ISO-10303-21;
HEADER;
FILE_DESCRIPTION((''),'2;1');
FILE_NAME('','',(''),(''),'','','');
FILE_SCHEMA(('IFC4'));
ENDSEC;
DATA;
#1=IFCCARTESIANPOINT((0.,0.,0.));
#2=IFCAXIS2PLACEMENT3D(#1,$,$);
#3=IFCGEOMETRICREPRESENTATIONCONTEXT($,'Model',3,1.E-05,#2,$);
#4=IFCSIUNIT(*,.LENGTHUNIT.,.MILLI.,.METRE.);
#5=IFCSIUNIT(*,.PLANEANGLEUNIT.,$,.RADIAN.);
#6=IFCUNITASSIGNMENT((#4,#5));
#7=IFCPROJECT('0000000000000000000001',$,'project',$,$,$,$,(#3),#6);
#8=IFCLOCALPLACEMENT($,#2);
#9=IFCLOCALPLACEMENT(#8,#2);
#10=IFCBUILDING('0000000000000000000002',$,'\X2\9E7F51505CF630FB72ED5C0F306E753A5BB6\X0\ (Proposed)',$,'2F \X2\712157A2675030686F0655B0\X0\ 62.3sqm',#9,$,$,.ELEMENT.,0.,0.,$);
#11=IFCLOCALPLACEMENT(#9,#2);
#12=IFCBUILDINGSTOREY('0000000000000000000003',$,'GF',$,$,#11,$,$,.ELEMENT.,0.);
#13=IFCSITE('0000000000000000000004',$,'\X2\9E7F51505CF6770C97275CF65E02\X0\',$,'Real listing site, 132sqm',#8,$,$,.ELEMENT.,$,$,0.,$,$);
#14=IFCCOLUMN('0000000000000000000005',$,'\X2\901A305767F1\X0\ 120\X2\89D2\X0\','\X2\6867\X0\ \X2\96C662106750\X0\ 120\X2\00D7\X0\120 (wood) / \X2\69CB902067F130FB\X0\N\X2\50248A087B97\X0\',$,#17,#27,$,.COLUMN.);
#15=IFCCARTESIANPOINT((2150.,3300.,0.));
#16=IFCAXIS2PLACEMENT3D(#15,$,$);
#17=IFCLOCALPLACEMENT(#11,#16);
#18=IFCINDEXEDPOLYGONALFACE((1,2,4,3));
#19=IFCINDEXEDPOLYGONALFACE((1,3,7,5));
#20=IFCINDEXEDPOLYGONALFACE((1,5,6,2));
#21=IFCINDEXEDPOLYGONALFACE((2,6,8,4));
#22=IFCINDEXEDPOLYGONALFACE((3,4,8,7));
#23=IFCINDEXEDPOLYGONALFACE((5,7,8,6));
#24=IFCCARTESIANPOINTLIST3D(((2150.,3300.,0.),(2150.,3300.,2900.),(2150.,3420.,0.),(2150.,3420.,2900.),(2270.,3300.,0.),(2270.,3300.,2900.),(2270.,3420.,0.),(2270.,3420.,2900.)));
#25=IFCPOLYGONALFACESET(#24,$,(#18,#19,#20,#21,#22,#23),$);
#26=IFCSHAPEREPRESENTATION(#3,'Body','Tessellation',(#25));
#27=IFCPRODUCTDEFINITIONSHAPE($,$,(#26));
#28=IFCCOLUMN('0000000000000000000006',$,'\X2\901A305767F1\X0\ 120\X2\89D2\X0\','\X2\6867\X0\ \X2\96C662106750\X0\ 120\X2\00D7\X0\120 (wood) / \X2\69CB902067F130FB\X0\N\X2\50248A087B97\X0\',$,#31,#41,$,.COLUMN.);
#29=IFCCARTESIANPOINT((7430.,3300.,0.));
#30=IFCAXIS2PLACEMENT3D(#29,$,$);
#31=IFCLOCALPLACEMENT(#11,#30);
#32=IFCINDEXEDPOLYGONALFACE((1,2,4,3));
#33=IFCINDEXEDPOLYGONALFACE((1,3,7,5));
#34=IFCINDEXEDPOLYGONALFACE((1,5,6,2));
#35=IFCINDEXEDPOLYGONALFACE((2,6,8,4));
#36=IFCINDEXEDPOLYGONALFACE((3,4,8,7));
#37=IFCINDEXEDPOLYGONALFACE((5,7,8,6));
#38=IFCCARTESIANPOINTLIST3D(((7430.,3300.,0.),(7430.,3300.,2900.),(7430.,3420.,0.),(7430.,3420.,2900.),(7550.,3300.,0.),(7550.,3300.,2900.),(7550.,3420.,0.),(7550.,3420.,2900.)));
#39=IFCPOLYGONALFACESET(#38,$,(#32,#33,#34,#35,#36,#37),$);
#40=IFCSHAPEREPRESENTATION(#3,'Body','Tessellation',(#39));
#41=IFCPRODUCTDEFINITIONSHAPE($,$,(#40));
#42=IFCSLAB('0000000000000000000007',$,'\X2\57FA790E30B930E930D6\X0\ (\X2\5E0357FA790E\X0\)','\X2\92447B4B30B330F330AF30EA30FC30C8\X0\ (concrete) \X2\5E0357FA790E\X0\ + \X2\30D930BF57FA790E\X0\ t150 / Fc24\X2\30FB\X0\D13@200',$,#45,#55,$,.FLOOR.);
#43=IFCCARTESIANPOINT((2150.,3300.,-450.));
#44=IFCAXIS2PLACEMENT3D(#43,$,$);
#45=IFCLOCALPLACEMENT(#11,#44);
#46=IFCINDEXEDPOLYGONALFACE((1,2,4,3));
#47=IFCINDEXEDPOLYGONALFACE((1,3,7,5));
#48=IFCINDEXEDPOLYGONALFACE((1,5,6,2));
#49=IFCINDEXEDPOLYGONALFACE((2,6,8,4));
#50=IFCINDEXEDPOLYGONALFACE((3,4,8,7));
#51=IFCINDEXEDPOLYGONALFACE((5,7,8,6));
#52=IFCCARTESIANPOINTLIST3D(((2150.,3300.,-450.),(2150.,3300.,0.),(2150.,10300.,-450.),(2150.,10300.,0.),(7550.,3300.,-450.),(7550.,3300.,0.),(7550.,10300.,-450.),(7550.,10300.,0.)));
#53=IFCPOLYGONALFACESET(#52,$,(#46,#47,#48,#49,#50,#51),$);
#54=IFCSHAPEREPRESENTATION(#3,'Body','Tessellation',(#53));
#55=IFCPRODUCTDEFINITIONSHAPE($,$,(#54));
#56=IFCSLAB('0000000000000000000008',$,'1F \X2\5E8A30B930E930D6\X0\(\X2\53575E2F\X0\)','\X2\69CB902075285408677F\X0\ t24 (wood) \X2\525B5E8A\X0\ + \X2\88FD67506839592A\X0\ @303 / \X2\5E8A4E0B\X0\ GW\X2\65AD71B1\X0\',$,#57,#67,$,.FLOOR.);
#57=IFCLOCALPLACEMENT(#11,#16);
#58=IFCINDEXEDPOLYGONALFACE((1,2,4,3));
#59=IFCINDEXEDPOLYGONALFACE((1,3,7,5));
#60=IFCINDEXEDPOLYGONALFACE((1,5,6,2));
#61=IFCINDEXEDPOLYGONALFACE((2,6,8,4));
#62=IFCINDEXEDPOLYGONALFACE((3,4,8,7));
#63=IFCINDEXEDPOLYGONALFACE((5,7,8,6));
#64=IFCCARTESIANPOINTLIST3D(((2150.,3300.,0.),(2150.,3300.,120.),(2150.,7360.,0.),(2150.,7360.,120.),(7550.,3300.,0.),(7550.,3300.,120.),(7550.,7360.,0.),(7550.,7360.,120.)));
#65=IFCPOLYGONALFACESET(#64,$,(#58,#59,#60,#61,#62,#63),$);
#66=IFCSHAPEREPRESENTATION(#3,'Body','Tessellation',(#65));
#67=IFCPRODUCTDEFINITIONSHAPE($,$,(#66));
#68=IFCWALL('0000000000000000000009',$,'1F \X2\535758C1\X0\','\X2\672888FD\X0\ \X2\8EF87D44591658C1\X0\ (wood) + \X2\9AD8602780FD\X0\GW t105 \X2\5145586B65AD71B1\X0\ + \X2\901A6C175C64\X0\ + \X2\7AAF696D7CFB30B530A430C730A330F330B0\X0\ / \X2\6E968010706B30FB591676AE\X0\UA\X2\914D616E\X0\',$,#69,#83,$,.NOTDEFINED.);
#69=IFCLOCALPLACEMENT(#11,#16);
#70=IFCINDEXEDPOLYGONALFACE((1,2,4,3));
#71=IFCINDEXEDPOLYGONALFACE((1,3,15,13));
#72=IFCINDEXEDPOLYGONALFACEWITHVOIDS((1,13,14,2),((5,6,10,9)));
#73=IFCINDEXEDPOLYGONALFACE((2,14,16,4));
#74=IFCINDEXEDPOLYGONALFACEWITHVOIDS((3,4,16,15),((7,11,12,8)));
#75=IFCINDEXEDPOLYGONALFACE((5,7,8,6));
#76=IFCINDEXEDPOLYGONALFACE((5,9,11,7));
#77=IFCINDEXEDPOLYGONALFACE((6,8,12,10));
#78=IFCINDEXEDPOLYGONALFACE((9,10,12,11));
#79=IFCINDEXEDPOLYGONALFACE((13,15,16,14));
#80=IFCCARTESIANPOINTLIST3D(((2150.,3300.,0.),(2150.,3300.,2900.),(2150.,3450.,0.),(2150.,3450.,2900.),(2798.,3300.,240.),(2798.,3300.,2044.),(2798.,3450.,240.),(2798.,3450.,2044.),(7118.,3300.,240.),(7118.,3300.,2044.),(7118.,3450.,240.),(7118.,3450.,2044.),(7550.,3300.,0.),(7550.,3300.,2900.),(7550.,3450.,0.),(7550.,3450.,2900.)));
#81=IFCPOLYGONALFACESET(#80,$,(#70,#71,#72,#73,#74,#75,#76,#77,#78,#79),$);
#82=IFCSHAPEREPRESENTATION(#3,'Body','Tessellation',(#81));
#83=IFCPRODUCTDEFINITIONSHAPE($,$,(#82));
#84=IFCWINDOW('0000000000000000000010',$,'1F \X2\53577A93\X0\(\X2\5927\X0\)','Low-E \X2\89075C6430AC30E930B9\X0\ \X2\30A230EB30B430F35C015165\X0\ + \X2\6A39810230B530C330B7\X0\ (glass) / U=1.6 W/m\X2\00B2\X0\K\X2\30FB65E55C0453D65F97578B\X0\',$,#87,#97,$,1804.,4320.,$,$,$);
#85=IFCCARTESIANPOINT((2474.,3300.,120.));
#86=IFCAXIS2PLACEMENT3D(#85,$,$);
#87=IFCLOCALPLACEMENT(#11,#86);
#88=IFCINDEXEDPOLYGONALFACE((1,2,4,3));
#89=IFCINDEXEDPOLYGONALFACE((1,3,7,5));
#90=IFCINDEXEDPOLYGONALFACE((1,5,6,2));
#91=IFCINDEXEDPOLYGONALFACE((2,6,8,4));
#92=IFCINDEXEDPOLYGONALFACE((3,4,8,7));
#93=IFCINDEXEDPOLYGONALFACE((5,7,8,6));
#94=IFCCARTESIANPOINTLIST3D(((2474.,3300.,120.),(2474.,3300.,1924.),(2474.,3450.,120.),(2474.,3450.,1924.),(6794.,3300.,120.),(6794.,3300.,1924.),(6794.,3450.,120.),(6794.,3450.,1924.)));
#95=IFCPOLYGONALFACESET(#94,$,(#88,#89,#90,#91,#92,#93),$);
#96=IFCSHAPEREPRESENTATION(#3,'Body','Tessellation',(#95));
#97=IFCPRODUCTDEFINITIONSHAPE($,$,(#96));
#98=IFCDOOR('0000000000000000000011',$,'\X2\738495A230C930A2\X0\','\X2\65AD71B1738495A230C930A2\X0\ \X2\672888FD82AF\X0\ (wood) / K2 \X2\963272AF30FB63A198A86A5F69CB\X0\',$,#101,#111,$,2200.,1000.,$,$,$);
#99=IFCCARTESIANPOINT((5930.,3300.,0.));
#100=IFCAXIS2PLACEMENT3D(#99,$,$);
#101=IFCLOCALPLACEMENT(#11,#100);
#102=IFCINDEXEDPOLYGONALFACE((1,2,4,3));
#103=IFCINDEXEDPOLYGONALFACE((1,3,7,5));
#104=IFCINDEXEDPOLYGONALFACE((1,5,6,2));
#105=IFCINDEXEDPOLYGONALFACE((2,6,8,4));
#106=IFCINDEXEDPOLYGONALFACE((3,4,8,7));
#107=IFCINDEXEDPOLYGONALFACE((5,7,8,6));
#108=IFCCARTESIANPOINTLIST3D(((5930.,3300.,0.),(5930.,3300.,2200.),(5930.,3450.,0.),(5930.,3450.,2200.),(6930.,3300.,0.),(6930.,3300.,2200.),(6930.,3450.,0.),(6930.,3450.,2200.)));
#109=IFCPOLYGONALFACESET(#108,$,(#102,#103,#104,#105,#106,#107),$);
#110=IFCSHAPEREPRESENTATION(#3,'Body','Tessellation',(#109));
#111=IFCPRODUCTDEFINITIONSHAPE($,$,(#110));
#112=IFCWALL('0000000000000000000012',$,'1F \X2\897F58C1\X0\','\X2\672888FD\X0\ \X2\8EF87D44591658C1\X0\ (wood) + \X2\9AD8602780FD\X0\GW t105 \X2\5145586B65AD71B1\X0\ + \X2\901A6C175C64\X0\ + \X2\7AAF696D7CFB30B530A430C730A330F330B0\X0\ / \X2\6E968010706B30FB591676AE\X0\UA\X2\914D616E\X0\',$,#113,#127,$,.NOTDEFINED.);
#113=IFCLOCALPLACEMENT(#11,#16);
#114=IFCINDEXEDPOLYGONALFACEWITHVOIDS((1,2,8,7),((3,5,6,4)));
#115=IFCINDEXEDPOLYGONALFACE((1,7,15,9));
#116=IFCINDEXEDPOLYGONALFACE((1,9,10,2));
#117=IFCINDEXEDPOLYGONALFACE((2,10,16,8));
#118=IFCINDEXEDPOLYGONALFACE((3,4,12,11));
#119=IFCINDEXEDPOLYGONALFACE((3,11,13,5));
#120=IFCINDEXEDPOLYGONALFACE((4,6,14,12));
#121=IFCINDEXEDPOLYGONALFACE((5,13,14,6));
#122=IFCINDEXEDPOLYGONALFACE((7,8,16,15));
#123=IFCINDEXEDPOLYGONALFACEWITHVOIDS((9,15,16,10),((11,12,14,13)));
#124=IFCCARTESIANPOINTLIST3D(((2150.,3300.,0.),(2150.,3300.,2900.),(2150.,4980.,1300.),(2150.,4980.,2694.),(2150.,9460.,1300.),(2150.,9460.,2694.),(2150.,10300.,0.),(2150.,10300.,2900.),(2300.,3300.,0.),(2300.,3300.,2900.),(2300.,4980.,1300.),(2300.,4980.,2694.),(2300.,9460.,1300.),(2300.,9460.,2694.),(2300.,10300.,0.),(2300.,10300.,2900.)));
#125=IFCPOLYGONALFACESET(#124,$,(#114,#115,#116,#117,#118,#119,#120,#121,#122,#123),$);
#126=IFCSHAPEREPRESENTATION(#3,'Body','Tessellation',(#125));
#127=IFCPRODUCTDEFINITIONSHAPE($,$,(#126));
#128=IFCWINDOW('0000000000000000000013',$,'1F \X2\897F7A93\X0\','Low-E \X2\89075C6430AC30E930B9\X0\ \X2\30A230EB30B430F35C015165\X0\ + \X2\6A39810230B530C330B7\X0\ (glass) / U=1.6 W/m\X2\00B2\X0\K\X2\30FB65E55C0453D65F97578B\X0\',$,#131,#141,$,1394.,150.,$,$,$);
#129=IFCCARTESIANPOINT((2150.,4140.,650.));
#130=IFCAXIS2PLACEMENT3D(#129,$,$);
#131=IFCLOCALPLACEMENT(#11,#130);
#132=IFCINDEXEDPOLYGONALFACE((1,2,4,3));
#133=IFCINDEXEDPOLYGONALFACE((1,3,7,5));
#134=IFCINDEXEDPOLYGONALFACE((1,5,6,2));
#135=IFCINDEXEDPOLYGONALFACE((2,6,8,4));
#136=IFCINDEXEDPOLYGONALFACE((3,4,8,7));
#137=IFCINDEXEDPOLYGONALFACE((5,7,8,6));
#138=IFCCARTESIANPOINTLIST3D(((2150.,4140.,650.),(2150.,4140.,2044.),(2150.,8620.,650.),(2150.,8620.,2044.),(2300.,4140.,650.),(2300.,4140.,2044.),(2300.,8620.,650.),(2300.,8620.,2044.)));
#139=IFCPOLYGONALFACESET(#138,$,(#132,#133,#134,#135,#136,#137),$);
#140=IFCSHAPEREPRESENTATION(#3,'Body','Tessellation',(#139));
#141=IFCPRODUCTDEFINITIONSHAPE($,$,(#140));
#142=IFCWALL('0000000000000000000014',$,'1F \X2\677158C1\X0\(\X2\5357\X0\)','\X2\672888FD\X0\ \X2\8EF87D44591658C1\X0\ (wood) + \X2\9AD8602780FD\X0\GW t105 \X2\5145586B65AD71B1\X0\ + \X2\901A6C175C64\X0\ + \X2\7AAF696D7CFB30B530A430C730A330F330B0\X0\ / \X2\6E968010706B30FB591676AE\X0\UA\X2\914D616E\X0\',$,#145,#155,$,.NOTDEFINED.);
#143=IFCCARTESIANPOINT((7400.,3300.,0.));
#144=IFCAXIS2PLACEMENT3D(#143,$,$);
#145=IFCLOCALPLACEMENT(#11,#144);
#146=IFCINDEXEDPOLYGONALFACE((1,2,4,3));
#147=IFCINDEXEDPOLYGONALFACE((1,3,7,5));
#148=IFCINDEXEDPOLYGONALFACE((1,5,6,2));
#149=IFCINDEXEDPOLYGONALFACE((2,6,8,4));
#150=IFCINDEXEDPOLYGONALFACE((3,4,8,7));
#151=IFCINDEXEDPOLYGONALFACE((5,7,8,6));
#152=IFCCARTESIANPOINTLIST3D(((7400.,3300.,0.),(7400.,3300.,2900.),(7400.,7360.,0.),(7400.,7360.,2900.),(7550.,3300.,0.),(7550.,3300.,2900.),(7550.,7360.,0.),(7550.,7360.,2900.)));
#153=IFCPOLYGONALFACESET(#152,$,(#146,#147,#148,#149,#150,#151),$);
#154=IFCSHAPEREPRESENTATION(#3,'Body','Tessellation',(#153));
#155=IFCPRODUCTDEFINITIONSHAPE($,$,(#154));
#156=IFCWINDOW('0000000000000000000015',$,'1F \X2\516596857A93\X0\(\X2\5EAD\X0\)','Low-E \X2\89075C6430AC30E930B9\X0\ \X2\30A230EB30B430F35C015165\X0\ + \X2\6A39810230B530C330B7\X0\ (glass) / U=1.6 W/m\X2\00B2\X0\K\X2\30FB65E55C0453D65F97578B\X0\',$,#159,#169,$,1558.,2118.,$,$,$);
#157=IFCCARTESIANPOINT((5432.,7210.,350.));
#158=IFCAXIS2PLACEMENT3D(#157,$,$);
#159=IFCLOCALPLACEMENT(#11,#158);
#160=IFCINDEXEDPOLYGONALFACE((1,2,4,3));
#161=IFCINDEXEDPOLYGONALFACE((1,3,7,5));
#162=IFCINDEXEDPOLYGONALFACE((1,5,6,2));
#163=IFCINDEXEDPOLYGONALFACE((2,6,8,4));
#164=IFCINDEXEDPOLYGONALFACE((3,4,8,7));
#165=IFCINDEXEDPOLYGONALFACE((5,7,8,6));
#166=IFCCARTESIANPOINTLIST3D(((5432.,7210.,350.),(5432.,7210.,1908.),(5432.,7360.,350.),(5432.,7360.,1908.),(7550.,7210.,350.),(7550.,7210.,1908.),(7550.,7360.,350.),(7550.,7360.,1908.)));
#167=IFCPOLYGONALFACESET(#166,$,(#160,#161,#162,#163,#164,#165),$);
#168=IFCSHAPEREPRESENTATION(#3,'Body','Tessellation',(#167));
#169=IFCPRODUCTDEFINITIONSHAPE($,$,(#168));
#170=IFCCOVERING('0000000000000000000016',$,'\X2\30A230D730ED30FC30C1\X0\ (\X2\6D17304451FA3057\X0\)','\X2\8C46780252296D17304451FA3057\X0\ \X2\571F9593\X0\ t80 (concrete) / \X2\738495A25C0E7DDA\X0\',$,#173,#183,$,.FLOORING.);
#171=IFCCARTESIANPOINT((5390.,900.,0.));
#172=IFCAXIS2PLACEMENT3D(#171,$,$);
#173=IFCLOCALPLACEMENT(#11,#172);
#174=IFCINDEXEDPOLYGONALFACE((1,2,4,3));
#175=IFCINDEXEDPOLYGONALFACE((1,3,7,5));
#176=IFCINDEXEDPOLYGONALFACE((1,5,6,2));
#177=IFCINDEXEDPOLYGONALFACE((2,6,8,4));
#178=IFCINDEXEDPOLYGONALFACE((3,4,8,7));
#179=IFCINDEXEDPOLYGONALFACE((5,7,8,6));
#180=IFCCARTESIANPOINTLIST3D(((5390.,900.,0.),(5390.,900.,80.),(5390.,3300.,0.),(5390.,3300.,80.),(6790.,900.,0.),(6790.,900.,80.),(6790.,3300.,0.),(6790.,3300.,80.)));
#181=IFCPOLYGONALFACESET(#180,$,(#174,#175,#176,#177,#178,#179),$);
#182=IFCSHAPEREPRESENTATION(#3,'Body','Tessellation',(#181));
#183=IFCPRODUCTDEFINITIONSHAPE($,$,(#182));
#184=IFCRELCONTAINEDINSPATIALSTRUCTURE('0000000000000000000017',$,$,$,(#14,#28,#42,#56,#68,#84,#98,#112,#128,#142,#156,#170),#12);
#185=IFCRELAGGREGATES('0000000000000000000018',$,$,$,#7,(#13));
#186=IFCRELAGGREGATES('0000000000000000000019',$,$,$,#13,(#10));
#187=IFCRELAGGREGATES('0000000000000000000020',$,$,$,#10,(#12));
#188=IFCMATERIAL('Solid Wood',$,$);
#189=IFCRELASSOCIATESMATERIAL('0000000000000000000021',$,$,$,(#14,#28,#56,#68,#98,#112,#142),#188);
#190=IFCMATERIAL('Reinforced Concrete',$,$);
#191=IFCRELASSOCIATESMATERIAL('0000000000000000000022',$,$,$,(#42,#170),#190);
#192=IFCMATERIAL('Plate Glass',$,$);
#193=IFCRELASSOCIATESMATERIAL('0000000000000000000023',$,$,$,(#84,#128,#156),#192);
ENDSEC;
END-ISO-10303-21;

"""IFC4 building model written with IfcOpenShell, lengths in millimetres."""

from ifc_helpers import new_model, si_unit, frame, frame_2d, origin, place, context, project, spatial, rectangle, extrude, material, element, fill, save


model = new_model("IFC4")

# Units and contexts
model_context = context("Model", 3, precision=1e-05, world=origin())
ifc_project = project(units=[si_unit("LENGTHUNIT", "METRE", prefix="MILLI"), si_unit("PLANEANGLEUNIT", "RADIAN")], contexts=[model_context])

# Site, building, storey
site_placement = place(None, origin())
site = spatial("IfcSite", under=ifc_project, at=site_placement, Name="鹿児島県霧島市", ObjectType="Real listing site, 132sqm", CompositionType="ELEMENT", RefElevation=0.0)
building_placement = place(site_placement, origin())
building = spatial("IfcBuilding", under=site, at=building_placement, Name="鹿児島・狭小の町家 (Proposed)", ObjectType="2F 無垢材と漆喰 62.3sqm", CompositionType="ELEMENT", ElevationOfRefHeight=0.0, ElevationOfTerrain=0.0)
storey_placement = place(building_placement, origin())
storey = spatial("IfcBuildingStorey", under=building, at=storey_placement, Name="GF", CompositionType="ELEMENT", Elevation=0.0)

# Columns
ifc_material_1 = material(Name="Solid Wood")
column_1_placement = place(storey_placement, frame((2150.0, 3300.0, 0.0)))
element("IfcColumn", 1, at=column_1_placement, inside=storey, material=ifc_material_1, Name="通し柱 120角", Description="桧 集成材 120×120 (wood) / 構造柱・N値計算", PredefinedType="COLUMN", context=model_context, shape_type="SweptSolid", body=[
    extrude(rectangle(XDim=120.0, YDim=120.0, at=frame_2d((60.0, 60.0))), frame((2150.0, 3300.0, 0.0)), (0.0, 0.0, 1.0), 2900.0),
])
column_2_placement = place(storey_placement, frame((7430.0, 3300.0, 0.0)))
element("IfcColumn", 2, at=column_2_placement, inside=storey, material=ifc_material_1, Name="通し柱 120角", Description="桧 集成材 120×120 (wood) / 構造柱・N値計算", PredefinedType="COLUMN", context=model_context, shape_type="SweptSolid", body=[
    extrude(rectangle(XDim=120.0, YDim=120.0, at=frame_2d((60.0, 60.0))), frame((7430.0, 3300.0, 0.0)), (0.0, 0.0, 1.0), 2900.0),
])

# Slabs
ifc_material_2 = material(Name="Reinforced Concrete")
slab_1_placement = place(storey_placement, frame((2150.0, 3300.0, -450.0)))
element("IfcSlab", 3, at=slab_1_placement, inside=storey, material=ifc_material_2, Name="基礎スラブ (布基礎)", Description="鉄筋コンクリート (concrete) 布基礎 + ベタ基礎 t150 / Fc24・D13@200", PredefinedType="FLOOR", context=model_context, shape_type="SweptSolid", body=[
    extrude(rectangle(XDim=5400.0, YDim=7000.0, at=frame_2d((2700.0, 3500.0))), frame((2150.0, 3300.0, -450.0)), (0.0, 0.0, 1.0), 450.0),
])
slab_2_placement = place(storey_placement, frame((2150.0, 3300.0, 0.0)))
element("IfcSlab", 4, at=slab_2_placement, inside=storey, material=ifc_material_1, Name="1F 床スラブ(南帯)", Description="構造用合板 t24 (wood) 剛床 + 製材根太 @303 / 床下 GW断熱", PredefinedType="FLOOR", context=model_context, shape_type="SweptSolid", body=[
    extrude(rectangle(XDim=5400.0, YDim=4060.0, at=frame_2d((2700.0, 2030.0))), frame((2150.0, 3300.0, 0.0)), (0.0, 0.0, 1.0), 120.0),
])

# Wall, openings, window, door
wall_1_placement = place(storey_placement, frame((2150.0, 3300.0, 0.0)))
wall_1 = element("IfcWall", 5, at=wall_1_placement, inside=storey, material=ifc_material_1, Name="1F 南壁", Description="木製 軸組外壁 (wood) + 高性能GW t105 充填断熱 + 通気層 + 窯業系サイディング / 準耐火・外皮UA配慮", PredefinedType="NOTDEFINED", context=model_context, shape_type="SweptSolid", body=[
    extrude(rectangle(XDim=5400.0, YDim=150.0, at=frame_2d((2700.0, 75.0))), frame((2150.0, 3300.0, 0.0)), (0.0, 0.0, 1.0), 2900.0),
])
opening_1_placement = place(storey_placement, frame((2474.0, 3300.0, 120.0)))
opening_1 = element("IfcOpeningElement", 6, at=opening_1_placement, cuts=wall_1, PredefinedType="NOTDEFINED", context=model_context, shape_type="SweptSolid", body=[
    extrude(rectangle(XDim=4320.0, YDim=150.0, at=frame_2d((2160.0, 75.0))), frame((2474.0, 3300.0, 120.0)), (0.0, 0.0, 1.0), 1804.0),
])
opening_2_placement = place(storey_placement, frame((5930.0, 3300.0, 0.0)))
opening_2 = element("IfcOpeningElement", 7, at=opening_2_placement, cuts=wall_1, PredefinedType="NOTDEFINED", context=model_context, shape_type="SweptSolid", body=[
    extrude(rectangle(XDim=1000.0, YDim=150.0, at=frame_2d((500.0, 75.0))), frame((5930.0, 3300.0, 0.0)), (0.0, 0.0, 1.0), 2200.0),
])
ifc_material_3 = material(Name="Plate Glass")
window_1_placement = place(storey_placement, frame((2474.0, 3300.0, 120.0)))
window_1 = element("IfcWindow", 8, at=window_1_placement, inside=storey, material=ifc_material_3, Name="1F 南窓(大)", Description="Low-E 複層ガラス アルゴン封入 + 樹脂サッシ (glass) / U=1.6 W/m²K・日射取得型", OverallHeight=1804.0, OverallWidth=4320.0, context=model_context, shape_type="SweptSolid", body=[
    extrude(rectangle(XDim=4320.0, YDim=150.0, at=frame_2d((2160.0, 75.0))), frame((2474.0, 3300.0, 120.0)), (0.0, 0.0, 1.0), 1804.0),
])
fill(opening_1, window_1)
door_1_placement = place(storey_placement, frame((5930.0, 3300.0, 0.0)))
door_1 = element("IfcDoor", 9, at=door_1_placement, inside=storey, material=ifc_material_1, Name="玄関ドア", Description="断熱玄関ドア 木製芯 (wood) / K2 防犯・採風機構", OverallHeight=2200.0, OverallWidth=1000.0, context=model_context, shape_type="SweptSolid", body=[
    extrude(rectangle(XDim=1000.0, YDim=150.0, at=frame_2d((500.0, 75.0))), frame((5930.0, 3300.0, 0.0)), (0.0, 0.0, 1.0), 2200.0),
])
fill(opening_2, door_1)

# Walls, openings, windows
wall_2_placement = place(storey_placement, frame((2150.0, 3300.0, 0.0)))
wall_2 = element("IfcWall", 10, at=wall_2_placement, inside=storey, material=ifc_material_1, Name="1F 西壁", Description="木製 軸組外壁 (wood) + 高性能GW t105 充填断熱 + 通気層 + 窯業系サイディング / 準耐火・外皮UA配慮", PredefinedType="NOTDEFINED", context=model_context, shape_type="SweptSolid", body=[
    extrude(rectangle(XDim=150.0, YDim=7000.0, at=frame_2d((75.0, 3500.0))), frame((2150.0, 3300.0, 0.0)), (0.0, 0.0, 1.0), 2900.0),
])
opening_3_placement = place(storey_placement, frame((2150.0, 4140.0, 650.0)))
opening_3 = element("IfcOpeningElement", 11, at=opening_3_placement, cuts=wall_2, PredefinedType="NOTDEFINED", context=model_context, shape_type="SweptSolid", body=[
    extrude(rectangle(XDim=150.0, YDim=4480.0, at=frame_2d((75.0, 2240.0))), frame((2150.0, 4140.0, 650.0)), (0.0, 0.0, 1.0), 1394.0),
])
window_2_placement = place(storey_placement, frame((2150.0, 4140.0, 650.0)))
window_2 = element("IfcWindow", 12, at=window_2_placement, inside=storey, material=ifc_material_3, Name="1F 西窓", Description="Low-E 複層ガラス アルゴン封入 + 樹脂サッシ (glass) / U=1.6 W/m²K・日射取得型", OverallHeight=1394.0, OverallWidth=150.0, context=model_context, shape_type="SweptSolid", body=[
    extrude(rectangle(XDim=150.0, YDim=4480.0, at=frame_2d((75.0, 2240.0))), frame((2150.0, 4140.0, 650.0)), (0.0, 0.0, 1.0), 1394.0),
])
fill(opening_3, window_2)
wall_3_placement = place(storey_placement, frame((7400.0, 3300.0, 0.0)))
wall_3 = element("IfcWall", 13, at=wall_3_placement, inside=storey, material=ifc_material_1, Name="1F 東壁(南)", Description="木製 軸組外壁 (wood) + 高性能GW t105 充填断熱 + 通気層 + 窯業系サイディング / 準耐火・外皮UA配慮", PredefinedType="NOTDEFINED", context=model_context, shape_type="SweptSolid", body=[
    extrude(rectangle(XDim=150.0, YDim=4060.0, at=frame_2d((75.0, 2030.0))), frame((7400.0, 3300.0, 0.0)), (0.0, 0.0, 1.0), 2900.0),
])
opening_4_placement = place(storey_placement, frame((5432.0, 7210.0, 350.0)))
opening_4 = element("IfcOpeningElement", 14, at=opening_4_placement, cuts=wall_3, PredefinedType="NOTDEFINED", context=model_context, shape_type="SweptSolid", body=[
    extrude(rectangle(XDim=2118.0, YDim=150.0, at=frame_2d((1059.0, 75.0))), frame((5432.0, 7210.0, 350.0)), (0.0, 0.0, 1.0), 1558.0),
])
window_3_placement = place(storey_placement, frame((5432.0, 7210.0, 350.0)))
window_3 = element("IfcWindow", 15, at=window_3_placement, inside=storey, material=ifc_material_3, Name="1F 入隅窓(庭)", Description="Low-E 複層ガラス アルゴン封入 + 樹脂サッシ (glass) / U=1.6 W/m²K・日射取得型", OverallHeight=1558.0, OverallWidth=2118.0, context=model_context, shape_type="SweptSolid", body=[
    extrude(rectangle(XDim=2118.0, YDim=150.0, at=frame_2d((1059.0, 75.0))), frame((5432.0, 7210.0, 350.0)), (0.0, 0.0, 1.0), 1558.0),
])
fill(opening_4, window_3)

# Covering
covering_1_placement = place(storey_placement, frame((5390.0, 900.0, 0.0)))
element("IfcCovering", 16, at=covering_1_placement, inside=storey, material=ifc_material_2, Name="アプローチ (洗い出し)", Description="豆砂利洗い出し 土間 t80 (concrete) / 玄関導線", PredefinedType="FLOORING", context=model_context, shape_type="SweptSolid", body=[
    extrude(rectangle(XDim=1400.0, YDim=2400.0, at=frame_2d((700.0, 1200.0))), frame((5390.0, 900.0, 0.0)), (0.0, 0.0, 1.0), 80.0),
])

save(model, "model.ifc")
